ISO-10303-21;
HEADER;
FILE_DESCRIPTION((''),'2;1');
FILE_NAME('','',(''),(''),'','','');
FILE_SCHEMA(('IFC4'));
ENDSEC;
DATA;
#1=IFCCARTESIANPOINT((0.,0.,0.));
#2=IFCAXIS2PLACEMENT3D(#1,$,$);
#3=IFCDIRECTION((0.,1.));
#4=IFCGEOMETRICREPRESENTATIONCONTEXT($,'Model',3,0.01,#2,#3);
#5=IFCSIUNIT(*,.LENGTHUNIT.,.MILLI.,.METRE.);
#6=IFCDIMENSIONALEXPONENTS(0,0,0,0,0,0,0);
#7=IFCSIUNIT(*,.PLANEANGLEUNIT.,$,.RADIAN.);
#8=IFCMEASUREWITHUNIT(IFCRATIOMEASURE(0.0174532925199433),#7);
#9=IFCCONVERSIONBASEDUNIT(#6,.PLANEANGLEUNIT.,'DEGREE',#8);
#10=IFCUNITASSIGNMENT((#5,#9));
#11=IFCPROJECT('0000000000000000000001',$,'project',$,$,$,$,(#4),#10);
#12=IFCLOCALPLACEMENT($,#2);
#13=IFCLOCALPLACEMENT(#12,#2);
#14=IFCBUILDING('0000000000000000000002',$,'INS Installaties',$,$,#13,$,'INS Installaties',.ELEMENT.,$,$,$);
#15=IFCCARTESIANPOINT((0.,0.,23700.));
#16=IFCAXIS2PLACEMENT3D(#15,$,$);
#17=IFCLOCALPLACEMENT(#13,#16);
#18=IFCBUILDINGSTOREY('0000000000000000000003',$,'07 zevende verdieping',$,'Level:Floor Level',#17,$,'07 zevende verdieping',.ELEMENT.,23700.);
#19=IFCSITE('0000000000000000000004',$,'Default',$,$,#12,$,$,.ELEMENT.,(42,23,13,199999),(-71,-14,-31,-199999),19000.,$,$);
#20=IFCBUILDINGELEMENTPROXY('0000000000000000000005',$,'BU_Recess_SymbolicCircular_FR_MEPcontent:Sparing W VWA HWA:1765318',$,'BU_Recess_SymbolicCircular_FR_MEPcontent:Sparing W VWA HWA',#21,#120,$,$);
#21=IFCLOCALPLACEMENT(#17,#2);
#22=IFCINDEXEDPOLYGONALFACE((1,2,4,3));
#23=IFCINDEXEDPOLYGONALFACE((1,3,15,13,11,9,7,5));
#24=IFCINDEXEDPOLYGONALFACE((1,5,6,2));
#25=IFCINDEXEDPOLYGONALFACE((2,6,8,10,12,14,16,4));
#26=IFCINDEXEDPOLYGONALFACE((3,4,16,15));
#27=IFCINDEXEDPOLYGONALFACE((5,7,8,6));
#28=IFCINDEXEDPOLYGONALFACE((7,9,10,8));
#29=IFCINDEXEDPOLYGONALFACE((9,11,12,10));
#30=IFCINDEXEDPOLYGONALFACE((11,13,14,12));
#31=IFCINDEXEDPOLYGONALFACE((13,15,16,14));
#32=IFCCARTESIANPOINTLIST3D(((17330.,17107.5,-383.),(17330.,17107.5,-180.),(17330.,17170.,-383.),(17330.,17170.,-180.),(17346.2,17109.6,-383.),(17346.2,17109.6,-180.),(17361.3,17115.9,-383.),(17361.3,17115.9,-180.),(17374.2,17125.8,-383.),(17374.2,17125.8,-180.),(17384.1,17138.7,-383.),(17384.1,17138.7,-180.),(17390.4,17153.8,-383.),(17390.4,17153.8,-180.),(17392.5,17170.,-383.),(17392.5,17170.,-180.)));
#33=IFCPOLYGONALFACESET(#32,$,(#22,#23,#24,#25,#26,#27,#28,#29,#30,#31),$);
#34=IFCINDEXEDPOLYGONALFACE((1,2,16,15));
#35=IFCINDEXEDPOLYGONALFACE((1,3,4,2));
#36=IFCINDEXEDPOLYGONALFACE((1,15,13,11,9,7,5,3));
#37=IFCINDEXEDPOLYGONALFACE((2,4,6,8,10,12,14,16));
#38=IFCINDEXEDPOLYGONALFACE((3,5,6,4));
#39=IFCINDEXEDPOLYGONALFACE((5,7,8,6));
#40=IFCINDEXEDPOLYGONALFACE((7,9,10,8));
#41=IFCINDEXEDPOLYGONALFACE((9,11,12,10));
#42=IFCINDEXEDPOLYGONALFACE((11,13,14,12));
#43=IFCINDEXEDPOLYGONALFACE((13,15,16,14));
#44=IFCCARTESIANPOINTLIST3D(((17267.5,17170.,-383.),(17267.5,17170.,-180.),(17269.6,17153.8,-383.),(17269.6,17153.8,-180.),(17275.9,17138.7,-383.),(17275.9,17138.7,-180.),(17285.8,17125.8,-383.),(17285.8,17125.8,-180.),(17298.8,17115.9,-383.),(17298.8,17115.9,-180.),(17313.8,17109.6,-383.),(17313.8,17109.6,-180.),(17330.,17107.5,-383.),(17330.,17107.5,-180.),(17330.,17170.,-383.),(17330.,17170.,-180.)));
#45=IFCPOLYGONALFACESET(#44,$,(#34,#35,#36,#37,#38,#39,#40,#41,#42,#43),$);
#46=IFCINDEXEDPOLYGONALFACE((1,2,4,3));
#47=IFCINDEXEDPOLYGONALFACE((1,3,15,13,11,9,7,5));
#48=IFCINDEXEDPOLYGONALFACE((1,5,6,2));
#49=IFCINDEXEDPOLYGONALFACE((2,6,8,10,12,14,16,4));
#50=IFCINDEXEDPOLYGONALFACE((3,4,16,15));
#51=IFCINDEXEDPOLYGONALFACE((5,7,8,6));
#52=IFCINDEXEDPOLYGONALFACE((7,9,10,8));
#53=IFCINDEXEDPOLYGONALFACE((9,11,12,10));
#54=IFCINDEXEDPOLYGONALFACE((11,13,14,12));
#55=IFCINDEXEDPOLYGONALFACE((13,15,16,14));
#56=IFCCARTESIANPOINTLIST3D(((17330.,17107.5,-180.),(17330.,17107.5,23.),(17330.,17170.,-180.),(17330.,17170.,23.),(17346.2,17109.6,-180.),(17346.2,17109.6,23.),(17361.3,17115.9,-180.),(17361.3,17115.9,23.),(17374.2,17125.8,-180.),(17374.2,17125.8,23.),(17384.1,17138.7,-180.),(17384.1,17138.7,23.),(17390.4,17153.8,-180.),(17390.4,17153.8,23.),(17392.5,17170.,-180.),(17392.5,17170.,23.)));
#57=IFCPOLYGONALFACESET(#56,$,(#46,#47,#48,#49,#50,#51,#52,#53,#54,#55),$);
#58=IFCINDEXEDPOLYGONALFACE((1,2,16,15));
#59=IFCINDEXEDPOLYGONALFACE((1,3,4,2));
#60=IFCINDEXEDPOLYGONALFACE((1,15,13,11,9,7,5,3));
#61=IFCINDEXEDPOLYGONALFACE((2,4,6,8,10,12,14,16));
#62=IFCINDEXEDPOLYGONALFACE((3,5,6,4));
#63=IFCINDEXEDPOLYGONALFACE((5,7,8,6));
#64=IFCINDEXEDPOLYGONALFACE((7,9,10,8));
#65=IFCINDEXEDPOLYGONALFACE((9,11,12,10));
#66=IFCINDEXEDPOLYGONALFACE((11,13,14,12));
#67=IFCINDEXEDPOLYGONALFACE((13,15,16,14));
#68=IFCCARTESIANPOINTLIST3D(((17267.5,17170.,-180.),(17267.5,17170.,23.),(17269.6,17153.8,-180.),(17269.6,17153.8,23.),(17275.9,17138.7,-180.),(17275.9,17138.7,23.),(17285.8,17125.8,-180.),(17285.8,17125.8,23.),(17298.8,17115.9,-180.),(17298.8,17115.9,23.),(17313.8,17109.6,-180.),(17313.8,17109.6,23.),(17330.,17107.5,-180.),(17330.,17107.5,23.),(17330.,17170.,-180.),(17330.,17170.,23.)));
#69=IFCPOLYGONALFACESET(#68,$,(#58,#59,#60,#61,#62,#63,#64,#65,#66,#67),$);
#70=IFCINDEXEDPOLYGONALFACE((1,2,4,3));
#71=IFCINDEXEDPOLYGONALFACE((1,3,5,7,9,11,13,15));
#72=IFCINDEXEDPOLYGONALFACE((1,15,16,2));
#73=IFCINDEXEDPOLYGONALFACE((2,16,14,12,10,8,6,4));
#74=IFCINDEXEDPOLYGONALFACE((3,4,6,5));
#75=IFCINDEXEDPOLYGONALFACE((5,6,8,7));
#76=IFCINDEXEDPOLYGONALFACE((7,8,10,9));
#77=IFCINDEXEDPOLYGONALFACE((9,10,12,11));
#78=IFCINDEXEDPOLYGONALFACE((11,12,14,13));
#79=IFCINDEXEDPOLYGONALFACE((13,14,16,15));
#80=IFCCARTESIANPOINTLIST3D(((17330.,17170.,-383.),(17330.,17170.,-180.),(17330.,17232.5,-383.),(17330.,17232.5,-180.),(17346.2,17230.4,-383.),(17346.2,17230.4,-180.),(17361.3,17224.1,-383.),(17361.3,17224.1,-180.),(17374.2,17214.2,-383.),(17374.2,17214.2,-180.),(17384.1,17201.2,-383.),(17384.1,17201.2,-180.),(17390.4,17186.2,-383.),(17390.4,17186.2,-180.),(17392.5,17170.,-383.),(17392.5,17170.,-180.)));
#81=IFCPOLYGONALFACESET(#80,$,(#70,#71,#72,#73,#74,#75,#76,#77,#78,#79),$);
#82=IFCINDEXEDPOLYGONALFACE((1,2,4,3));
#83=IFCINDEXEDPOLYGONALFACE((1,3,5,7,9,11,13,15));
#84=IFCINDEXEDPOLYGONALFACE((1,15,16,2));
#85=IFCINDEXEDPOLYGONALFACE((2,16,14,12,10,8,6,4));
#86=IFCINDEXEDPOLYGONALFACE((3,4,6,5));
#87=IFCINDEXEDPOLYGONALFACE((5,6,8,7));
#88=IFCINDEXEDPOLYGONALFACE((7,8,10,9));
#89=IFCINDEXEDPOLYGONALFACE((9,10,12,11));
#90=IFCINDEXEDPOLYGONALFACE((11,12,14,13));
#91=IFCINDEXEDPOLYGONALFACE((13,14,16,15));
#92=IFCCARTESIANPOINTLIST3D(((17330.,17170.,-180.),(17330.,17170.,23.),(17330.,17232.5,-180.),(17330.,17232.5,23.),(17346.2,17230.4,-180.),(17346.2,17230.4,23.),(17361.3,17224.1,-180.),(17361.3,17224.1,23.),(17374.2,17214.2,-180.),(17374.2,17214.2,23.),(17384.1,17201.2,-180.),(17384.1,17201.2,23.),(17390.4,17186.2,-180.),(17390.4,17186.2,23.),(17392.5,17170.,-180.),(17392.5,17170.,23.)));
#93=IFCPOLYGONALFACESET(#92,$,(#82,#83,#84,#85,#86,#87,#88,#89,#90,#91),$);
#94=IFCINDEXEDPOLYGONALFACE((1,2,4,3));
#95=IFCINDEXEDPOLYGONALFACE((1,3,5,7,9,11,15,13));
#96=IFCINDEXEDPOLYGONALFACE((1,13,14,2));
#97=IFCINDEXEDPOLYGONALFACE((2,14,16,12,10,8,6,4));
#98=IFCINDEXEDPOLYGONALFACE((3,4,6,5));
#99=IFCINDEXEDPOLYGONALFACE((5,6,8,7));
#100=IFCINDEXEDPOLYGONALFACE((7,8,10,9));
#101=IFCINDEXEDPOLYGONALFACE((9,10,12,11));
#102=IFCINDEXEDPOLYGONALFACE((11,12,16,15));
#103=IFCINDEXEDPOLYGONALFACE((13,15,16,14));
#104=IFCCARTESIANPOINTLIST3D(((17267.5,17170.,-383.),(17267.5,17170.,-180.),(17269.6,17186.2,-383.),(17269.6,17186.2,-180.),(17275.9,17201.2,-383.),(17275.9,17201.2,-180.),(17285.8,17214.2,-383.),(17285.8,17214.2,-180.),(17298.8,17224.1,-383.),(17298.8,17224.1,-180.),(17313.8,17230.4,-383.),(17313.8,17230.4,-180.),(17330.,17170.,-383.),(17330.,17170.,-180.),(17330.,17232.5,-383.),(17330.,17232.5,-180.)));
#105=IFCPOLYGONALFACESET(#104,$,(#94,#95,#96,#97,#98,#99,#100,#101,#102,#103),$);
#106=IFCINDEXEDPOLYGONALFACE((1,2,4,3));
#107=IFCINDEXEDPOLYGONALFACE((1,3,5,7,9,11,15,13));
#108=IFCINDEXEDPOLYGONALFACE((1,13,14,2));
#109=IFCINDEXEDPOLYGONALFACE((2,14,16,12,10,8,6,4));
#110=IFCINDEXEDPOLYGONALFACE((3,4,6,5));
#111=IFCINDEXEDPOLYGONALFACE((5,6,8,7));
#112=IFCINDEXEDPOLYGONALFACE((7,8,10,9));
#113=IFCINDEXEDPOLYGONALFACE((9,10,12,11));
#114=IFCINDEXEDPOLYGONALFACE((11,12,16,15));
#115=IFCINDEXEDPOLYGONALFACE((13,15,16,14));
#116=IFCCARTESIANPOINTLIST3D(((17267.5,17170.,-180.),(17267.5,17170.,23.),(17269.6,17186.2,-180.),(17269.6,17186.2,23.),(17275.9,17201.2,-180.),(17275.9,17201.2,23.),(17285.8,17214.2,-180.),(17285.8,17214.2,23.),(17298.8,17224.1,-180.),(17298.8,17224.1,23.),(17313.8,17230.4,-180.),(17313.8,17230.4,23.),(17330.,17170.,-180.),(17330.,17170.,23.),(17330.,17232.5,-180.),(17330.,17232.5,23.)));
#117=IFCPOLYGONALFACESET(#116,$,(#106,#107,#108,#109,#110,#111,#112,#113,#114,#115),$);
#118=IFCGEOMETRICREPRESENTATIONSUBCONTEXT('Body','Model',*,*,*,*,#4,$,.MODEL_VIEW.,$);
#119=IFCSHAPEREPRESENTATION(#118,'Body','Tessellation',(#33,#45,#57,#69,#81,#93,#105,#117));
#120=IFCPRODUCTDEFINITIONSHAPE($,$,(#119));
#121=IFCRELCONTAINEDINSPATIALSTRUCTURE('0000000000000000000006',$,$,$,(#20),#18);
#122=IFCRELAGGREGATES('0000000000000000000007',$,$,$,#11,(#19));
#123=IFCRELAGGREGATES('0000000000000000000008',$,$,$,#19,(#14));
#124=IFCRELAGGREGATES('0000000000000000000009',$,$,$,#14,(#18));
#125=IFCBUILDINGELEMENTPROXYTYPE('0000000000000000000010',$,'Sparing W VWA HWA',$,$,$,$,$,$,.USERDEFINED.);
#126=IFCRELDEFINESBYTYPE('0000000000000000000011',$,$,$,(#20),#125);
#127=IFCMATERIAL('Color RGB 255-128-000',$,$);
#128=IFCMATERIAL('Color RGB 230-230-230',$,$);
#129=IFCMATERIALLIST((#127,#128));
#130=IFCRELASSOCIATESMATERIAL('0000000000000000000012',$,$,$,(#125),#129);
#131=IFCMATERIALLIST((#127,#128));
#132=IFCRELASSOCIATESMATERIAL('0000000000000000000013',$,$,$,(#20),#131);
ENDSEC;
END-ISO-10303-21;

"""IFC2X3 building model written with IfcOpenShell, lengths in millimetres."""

from ifc_helpers import new_model, entity, si_unit, converted_unit, direction, frame, frame_2d, origin, place, context, subcontext, project, spatial, polyline, circle_curve, parameter, trimmed, segment, composite_curve, outline, extrude, source, transform, mapped, material, material_list, type_object, type_shapes, element, save


model = new_model("IFC2X3")

# Units and contexts
model_context = context("Model", 3, precision=0.01, world=origin(), true_north=direction((0.0, 1.0)))
body_context = subcontext(model_context, "Body", "Model", "MODEL_VIEW")
ifc_project = project(units=[si_unit("LENGTHUNIT", "METRE", prefix="MILLI"), converted_unit("PLANEANGLEUNIT", "DEGREE", entity("IfcRatioMeasure", 0.0174532925199433), si_unit("PLANEANGLEUNIT", "RADIAN"), dimensions=[0, 0, 0, 0, 0, 0, 0])], contexts=[model_context])

# Site, building, storey
site_placement = place(None, origin())
site = spatial("IfcSite", under=ifc_project, at=site_placement, Name="Default", CompositionType="ELEMENT", RefLatitude=(42, 23, 13, 199999), RefLongitude=(-71, -14, -31, -199999), RefElevation=19000.0)
building_placement = place(site_placement, origin())
building = spatial("IfcBuilding", under=site, at=building_placement, Name="INS Installaties", LongName="INS Installaties", CompositionType="ELEMENT")
storey_placement = place(building_placement, frame((0.0, 0.0, 23700.0)))
storey = spatial("IfcBuildingStorey", under=building, at=storey_placement, Name="07 zevende verdieping", ObjectType="Level:Floor Level", LongName="07 zevende verdieping", CompositionType="ELEMENT", Elevation=23700.0)

# Building element proxy
ifc_material_1 = material(Name="Color RGB 255-128-000")
ifc_material_2 = material(Name="Color RGB 230-230-230")
ifc_material_list_1 = material_list([ifc_material_1, ifc_material_2])
building_element_proxy_type_1 = type_object("IfcBuildingElementProxyType", Name="Sparing W VWA HWA", PredefinedType="USERDEFINED", material=ifc_material_list_1)
shared_shape_1 = source(origin(), body_context, "Body", "SweptSolid", [
    extrude(outline(composite_curve([segment(polyline([(-41.7, -20.8), (20.8, -20.8)]), True, "CONTINUOUS"), segment(polyline([(20.8, -20.8), (20.8, 41.7)]), True, "CONTINUOUS"), segment(trimmed(circle_curve(frame_2d((20.8, -20.8), x_axis=(1.0, 0.0)), 62.5), [parameter(90.0)], [parameter(180.0)], True, "PARAMETER"), True, "CONTINUOUS")], self_intersect=False)), frame((20.8, -20.8, -403.0), z_axis=(0.0, 0.0, 1.0), x_axis=(-1.0, 0.0, 0.0)), (0.0, 0.0, 1.0), 203.0),
    extrude(outline(composite_curve([segment(trimmed(circle_curve(frame_2d((20.8, 20.8), x_axis=(1.0, 0.0)), 62.5), [parameter(180.0)], [parameter(270.0)], True, "PARAMETER"), True, "CONTINUOUS"), segment(polyline([(20.8, -41.7), (20.8, 20.8)]), True, "CONTINUOUS"), segment(polyline([(20.8, 20.8), (-41.7, 20.8)]), True, "CONTINUOUS")], self_intersect=False)), frame((-20.8, -20.8, -403.0)), (0.0, 0.0, 1.0), 203.0),
    extrude(outline(composite_curve([segment(polyline([(-41.7, -20.8), (20.8, -20.8)]), True, "CONTINUOUS"), segment(polyline([(20.8, -20.8), (20.8, 41.7)]), True, "CONTINUOUS"), segment(trimmed(circle_curve(frame_2d((20.8, -20.8), x_axis=(1.0, 0.0)), 62.5), [parameter(90.0)], [parameter(180.0)], True, "PARAMETER"), True, "CONTINUOUS")], self_intersect=False)), frame((20.8, -20.8, -200.0), z_axis=(0.0, 0.0, 1.0), x_axis=(-1.0, 0.0, 0.0)), (0.0, 0.0, 1.0), 203.0),
    extrude(outline(composite_curve([segment(trimmed(circle_curve(frame_2d((20.8, 20.8), x_axis=(1.0, 0.0)), 62.5), [parameter(180.0)], [parameter(270.0)], True, "PARAMETER"), True, "CONTINUOUS"), segment(polyline([(20.8, -41.7), (20.8, 20.8)]), True, "CONTINUOUS"), segment(polyline([(20.8, 20.8), (-41.7, 20.8)]), True, "CONTINUOUS")], self_intersect=False)), frame((-20.8, -20.8, -200.0)), (0.0, 0.0, 1.0), 203.0),
    extrude(outline(composite_curve([segment(trimmed(circle_curve(frame_2d((20.8, 20.8), x_axis=(1.0, 0.0)), 62.5), [parameter(180.0)], [parameter(270.0)], True, "PARAMETER"), True, "CONTINUOUS"), segment(polyline([(20.8, -41.7), (20.8, 20.8)]), True, "CONTINUOUS"), segment(polyline([(20.8, 20.8), (-41.7, 20.8)]), True, "CONTINUOUS")], self_intersect=False)), frame((20.8, 20.8, -403.0), z_axis=(0.0, 0.0, 1.0), x_axis=(-1.0, 0.0, 0.0)), (0.0, 0.0, 1.0), 203.0),
    extrude(outline(composite_curve([segment(trimmed(circle_curve(frame_2d((20.8, 20.8), x_axis=(1.0, 0.0)), 62.5), [parameter(180.0)], [parameter(270.0)], True, "PARAMETER"), True, "CONTINUOUS"), segment(polyline([(20.8, -41.7), (20.8, 20.8)]), True, "CONTINUOUS"), segment(polyline([(20.8, 20.8), (-41.7, 20.8)]), True, "CONTINUOUS")], self_intersect=False)), frame((20.8, 20.8, -200.0), z_axis=(0.0, 0.0, 1.0), x_axis=(-1.0, 0.0, 0.0)), (0.0, 0.0, 1.0), 203.0),
    extrude(outline(composite_curve([segment(polyline([(-41.7, -20.8), (20.8, -20.8)]), True, "CONTINUOUS"), segment(polyline([(20.8, -20.8), (20.8, 41.7)]), True, "CONTINUOUS"), segment(trimmed(circle_curve(frame_2d((20.8, -20.8), x_axis=(1.0, 0.0)), 62.5), [parameter(90.0)], [parameter(180.0)], True, "PARAMETER"), True, "CONTINUOUS")], self_intersect=False)), frame((-20.8, 20.8, -403.0)), (0.0, 0.0, 1.0), 203.0),
    extrude(outline(composite_curve([segment(polyline([(-41.7, -20.8), (20.8, -20.8)]), True, "CONTINUOUS"), segment(polyline([(20.8, -20.8), (20.8, 41.7)]), True, "CONTINUOUS"), segment(trimmed(circle_curve(frame_2d((20.8, -20.8), x_axis=(1.0, 0.0)), 62.5), [parameter(90.0)], [parameter(180.0)], True, "PARAMETER"), True, "CONTINUOUS")], self_intersect=False)), frame((-20.8, 20.8, -200.0)), (0.0, 0.0, 1.0), 203.0),
])
type_shapes(building_element_proxy_type_1, [shared_shape_1])
ifc_material_list_2 = material_list([ifc_material_1, ifc_material_2])
proxy_1_placement = place(storey_placement, frame((17330.0, 17170.0, 20.0)))
element("IfcBuildingElementProxy", 1, at=proxy_1_placement, inside=storey, type_object=building_element_proxy_type_1, material=ifc_material_list_2, Name="BU_Recess_SymbolicCircular_FR_MEPcontent:Sparing W VWA HWA:1765318", ObjectType="BU_Recess_SymbolicCircular_FR_MEPcontent:Sparing W VWA HWA", context=body_context, shape_type="MappedRepresentation", body=[
    mapped(shared_shape_1, transform((0.0, 0.0, 0.0), scale=1.0)),
])

save(model, "model.ifc")
